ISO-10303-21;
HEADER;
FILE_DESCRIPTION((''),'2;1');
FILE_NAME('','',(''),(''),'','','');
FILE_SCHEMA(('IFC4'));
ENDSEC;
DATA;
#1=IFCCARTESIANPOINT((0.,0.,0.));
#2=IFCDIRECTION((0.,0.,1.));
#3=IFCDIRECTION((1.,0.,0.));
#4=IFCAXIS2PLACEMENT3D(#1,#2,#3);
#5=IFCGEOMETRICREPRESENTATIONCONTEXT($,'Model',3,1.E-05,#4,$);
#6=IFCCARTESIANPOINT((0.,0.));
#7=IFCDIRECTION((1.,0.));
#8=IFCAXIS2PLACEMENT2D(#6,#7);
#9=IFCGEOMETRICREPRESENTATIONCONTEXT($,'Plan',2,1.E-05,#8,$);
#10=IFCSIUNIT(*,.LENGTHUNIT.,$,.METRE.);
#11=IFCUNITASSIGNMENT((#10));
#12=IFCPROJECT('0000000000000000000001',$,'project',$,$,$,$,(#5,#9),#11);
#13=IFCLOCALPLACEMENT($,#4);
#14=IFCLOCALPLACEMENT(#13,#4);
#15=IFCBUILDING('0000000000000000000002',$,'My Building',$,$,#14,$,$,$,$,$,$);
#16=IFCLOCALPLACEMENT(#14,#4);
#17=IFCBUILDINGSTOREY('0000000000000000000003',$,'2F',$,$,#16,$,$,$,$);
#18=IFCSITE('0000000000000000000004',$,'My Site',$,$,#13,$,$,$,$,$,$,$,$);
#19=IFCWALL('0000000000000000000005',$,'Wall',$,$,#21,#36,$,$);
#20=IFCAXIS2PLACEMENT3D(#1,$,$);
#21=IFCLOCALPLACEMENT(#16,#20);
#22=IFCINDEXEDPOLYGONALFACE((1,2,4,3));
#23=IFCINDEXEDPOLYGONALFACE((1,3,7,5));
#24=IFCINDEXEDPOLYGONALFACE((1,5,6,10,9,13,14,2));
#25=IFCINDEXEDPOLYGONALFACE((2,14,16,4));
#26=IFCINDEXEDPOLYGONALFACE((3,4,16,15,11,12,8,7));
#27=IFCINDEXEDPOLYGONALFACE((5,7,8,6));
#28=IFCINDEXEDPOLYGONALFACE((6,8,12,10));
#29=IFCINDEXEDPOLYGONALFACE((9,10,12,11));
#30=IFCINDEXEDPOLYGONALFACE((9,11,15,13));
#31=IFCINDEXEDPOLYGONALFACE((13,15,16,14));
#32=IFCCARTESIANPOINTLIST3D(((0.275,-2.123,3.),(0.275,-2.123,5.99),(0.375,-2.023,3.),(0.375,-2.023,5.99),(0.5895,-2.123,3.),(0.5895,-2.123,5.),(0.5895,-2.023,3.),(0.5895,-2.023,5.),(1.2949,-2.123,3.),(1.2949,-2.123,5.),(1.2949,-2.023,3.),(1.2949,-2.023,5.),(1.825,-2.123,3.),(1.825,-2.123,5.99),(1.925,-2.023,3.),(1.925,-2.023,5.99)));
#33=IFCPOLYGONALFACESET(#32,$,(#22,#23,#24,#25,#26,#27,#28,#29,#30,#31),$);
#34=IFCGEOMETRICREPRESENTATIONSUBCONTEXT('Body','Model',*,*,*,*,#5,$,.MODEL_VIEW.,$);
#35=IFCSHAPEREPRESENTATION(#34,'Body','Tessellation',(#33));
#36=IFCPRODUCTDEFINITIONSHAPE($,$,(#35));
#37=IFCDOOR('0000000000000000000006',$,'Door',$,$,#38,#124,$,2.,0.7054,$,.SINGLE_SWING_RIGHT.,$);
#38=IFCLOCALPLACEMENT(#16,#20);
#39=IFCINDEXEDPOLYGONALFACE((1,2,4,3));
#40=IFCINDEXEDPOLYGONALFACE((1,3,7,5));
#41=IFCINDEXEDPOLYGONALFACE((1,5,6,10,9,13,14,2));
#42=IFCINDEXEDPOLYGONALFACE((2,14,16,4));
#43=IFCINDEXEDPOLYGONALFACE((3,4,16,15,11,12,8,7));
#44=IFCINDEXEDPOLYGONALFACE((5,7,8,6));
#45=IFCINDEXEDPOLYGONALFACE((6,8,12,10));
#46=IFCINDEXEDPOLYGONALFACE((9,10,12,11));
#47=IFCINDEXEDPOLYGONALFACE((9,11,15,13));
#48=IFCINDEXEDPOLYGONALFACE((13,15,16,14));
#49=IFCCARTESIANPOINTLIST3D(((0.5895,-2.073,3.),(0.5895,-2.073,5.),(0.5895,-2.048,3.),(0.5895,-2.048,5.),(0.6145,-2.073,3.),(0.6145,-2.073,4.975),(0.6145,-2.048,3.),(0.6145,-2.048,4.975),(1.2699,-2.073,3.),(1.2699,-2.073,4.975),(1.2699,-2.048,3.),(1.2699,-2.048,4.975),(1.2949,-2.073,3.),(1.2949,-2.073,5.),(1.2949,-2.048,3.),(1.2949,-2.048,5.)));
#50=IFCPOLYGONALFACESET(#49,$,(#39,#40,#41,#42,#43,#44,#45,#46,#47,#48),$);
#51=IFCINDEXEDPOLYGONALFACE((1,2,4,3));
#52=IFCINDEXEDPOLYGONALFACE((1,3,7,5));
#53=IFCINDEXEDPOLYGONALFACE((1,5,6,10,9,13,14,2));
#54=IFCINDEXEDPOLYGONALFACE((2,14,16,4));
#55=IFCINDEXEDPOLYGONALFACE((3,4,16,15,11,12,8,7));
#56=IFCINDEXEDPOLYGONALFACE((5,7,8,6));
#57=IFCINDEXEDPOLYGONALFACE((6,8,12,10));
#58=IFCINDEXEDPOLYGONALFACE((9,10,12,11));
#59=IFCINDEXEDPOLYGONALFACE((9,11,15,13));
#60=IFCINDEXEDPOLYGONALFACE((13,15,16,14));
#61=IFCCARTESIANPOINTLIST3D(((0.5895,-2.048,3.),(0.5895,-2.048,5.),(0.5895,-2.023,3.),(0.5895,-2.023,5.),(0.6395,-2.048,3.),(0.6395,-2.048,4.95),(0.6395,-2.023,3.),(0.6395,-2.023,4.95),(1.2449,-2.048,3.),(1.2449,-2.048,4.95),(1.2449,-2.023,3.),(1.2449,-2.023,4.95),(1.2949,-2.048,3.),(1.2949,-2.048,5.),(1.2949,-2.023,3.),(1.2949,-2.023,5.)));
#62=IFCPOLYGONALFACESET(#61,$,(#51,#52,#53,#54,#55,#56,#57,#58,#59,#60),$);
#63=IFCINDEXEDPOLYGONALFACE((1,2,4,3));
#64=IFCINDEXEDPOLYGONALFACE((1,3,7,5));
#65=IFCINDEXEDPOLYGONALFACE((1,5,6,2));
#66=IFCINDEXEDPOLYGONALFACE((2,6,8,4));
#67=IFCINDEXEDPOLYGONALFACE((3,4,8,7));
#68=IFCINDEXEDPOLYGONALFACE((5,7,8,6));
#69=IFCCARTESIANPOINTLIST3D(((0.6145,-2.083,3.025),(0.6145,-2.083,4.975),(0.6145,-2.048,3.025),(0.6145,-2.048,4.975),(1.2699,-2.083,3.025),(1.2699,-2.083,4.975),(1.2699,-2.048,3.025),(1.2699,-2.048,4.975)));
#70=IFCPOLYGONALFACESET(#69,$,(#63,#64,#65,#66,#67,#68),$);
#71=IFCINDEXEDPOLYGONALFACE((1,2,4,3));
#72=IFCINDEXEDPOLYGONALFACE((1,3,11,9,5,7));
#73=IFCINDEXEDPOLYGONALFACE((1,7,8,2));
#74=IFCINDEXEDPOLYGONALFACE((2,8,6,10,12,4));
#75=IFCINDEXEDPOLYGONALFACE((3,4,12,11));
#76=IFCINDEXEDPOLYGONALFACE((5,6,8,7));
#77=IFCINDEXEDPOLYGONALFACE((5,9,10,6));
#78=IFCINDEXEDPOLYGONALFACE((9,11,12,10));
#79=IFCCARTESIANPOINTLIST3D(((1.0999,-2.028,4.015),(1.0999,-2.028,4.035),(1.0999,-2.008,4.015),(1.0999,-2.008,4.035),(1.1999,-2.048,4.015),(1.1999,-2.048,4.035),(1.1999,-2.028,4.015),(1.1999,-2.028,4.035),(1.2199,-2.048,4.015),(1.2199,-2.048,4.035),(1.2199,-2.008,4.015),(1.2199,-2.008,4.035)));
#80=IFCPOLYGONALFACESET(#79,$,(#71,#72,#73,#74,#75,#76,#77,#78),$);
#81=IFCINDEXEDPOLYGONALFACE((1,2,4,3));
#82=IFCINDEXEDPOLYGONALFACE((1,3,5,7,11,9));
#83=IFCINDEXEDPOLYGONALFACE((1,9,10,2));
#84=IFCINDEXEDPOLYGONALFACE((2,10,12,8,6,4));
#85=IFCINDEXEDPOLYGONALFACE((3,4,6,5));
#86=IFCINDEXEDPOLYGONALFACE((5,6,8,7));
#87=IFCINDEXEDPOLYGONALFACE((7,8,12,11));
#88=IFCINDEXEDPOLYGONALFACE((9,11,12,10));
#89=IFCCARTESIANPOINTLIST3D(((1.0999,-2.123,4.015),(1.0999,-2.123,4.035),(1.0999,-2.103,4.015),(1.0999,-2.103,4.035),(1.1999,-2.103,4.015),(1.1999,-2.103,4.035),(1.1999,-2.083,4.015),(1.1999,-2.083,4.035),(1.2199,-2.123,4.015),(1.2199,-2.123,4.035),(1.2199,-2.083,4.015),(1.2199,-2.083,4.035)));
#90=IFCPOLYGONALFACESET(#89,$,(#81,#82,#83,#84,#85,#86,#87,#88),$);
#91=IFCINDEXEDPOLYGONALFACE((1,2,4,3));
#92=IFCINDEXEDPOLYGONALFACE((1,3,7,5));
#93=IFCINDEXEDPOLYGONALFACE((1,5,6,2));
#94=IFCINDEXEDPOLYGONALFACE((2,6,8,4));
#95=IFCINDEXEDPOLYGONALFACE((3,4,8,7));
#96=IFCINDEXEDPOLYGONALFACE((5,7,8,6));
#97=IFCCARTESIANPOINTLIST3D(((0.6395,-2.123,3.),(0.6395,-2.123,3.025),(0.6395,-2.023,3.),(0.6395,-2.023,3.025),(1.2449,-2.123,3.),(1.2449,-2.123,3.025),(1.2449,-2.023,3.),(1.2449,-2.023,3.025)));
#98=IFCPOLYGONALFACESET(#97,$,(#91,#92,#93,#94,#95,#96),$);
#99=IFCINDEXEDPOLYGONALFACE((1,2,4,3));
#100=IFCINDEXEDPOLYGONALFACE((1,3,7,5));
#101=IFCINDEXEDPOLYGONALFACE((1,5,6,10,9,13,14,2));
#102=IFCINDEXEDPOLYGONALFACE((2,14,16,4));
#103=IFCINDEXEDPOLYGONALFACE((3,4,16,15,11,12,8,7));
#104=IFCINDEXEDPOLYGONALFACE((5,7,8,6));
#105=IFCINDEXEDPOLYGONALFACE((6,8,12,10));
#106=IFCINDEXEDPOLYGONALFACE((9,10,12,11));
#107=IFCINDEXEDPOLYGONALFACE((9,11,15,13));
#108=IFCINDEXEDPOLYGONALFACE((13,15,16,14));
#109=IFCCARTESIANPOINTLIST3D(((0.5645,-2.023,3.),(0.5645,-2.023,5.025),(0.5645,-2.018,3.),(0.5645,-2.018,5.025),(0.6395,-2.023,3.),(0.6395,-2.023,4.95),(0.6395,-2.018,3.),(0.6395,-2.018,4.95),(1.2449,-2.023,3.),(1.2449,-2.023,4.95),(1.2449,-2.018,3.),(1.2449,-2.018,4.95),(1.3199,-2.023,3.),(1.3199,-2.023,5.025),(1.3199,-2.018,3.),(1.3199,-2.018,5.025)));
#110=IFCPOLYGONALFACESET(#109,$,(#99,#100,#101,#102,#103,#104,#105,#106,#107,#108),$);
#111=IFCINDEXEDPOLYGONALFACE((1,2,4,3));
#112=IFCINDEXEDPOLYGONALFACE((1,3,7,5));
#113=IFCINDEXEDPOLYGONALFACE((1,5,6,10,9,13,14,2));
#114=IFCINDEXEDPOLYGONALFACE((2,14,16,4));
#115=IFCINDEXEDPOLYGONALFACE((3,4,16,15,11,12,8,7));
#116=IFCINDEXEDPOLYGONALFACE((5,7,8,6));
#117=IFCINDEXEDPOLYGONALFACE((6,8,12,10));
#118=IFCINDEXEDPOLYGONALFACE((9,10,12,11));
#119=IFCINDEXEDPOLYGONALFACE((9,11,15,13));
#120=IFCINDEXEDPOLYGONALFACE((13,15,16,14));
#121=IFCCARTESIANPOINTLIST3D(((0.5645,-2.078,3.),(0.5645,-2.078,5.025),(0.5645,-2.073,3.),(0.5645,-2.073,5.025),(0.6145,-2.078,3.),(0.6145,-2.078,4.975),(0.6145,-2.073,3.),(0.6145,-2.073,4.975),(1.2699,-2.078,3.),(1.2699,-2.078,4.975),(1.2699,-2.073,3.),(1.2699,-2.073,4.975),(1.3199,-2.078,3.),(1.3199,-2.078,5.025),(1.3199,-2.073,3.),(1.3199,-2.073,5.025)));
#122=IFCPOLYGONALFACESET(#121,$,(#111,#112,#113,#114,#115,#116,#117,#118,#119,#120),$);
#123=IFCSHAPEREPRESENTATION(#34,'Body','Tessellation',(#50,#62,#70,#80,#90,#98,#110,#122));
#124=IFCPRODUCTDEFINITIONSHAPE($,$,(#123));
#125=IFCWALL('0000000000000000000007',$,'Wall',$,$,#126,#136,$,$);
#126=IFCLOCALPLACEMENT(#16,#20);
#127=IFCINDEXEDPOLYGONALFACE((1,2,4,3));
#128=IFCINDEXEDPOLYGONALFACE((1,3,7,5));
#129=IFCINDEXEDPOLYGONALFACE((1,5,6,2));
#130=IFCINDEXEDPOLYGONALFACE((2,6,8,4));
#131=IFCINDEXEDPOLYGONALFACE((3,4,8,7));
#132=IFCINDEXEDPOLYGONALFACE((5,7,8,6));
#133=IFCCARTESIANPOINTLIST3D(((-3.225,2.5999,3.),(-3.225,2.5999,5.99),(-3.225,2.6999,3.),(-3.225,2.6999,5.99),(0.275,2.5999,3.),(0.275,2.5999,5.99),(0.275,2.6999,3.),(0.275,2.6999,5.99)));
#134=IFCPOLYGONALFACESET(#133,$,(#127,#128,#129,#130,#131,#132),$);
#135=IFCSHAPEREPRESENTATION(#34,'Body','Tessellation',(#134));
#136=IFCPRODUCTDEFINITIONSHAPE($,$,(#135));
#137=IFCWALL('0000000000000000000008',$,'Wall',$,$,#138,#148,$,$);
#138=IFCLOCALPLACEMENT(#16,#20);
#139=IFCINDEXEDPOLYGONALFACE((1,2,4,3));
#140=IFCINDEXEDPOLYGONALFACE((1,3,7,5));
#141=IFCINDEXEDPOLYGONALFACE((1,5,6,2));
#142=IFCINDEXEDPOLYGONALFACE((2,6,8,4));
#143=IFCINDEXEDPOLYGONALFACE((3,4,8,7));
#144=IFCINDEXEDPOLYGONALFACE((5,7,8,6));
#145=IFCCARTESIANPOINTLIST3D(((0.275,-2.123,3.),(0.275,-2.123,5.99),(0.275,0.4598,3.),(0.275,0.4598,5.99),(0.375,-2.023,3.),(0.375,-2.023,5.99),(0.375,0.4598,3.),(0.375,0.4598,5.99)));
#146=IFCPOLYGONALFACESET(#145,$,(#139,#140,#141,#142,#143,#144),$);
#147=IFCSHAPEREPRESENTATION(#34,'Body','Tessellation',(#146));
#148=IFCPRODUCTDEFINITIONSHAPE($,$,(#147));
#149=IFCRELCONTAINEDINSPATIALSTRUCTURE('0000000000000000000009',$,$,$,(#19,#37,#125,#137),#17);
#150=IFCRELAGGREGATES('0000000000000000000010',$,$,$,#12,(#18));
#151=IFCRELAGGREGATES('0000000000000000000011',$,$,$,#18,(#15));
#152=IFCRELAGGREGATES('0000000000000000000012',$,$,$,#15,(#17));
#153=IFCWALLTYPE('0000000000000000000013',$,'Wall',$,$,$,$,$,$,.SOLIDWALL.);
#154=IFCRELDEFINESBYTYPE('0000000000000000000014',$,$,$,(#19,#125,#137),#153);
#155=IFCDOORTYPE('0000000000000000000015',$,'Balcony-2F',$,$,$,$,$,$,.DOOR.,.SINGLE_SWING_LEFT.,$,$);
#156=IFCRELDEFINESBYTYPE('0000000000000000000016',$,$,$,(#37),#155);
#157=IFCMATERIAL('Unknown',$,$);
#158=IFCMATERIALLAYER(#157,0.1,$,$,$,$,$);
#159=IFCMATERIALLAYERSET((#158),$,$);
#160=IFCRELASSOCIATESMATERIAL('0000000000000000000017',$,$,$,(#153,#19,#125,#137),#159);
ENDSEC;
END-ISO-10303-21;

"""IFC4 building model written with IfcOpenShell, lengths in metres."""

from ifc_helpers import new_model, entity, si_unit, frame, origin_with_axes, origin_2d_with_axis, place, context, subcontext, project, spatial, line, indexed_curve, outline, extrude, shape, source, transform, mapped, material, layer, layer_set, layer_usage, type_object, type_shapes, element, fill, save


model = new_model("IFC4")

# Units and contexts
model_context = context("Model", 3, precision=1e-05, world=origin_with_axes())
plan_context = context("Plan", 2, precision=1e-05, world=origin_2d_with_axis())
body_context_1 = subcontext(model_context, "Body", "Model", "MODEL_VIEW")
body_context_2 = subcontext(plan_context, "Body", "Plan", "PLAN_VIEW")
ifc_project = project(units=[si_unit("LENGTHUNIT", "METRE")], contexts=[model_context, plan_context])

# Site, building, storey
site_placement = place(None, origin_with_axes())
site = spatial("IfcSite", under=ifc_project, at=site_placement, Name="My Site")
building_placement = place(site_placement, origin_with_axes())
building = spatial("IfcBuilding", under=site, at=building_placement, Name="My Building")
storey_placement = place(building_placement, origin_with_axes())
storey = spatial("IfcBuildingStorey", under=building, at=storey_placement, Name="2F")

# Shared definitions
ifc_material = material(Name="Unknown")

# Shared definitions
ifc_layer_1 = layer(ifc_material, 0.1)
ifc_layer_set_1 = layer_set([ifc_layer_1])
wall_type = type_object("IfcWallType", Name="Wall", PredefinedType="SOLIDWALL", material=ifc_layer_set_1)

# Wall, opening, door
ifc_layer_usage_1 = layer_usage(ifc_layer_set_1, "AXIS2", "POSITIVE", 0.0)
wall_1_placement = place(storey_placement, frame((0.275, -2.123, 3.0), z_axis=(0.0, 0.0, 1.0), x_axis=(1.0, 0.000001, 0.0)))
wall_1 = element("IfcWall", 1, at=wall_1_placement, inside=storey, type_object=wall_type, material=ifc_layer_usage_1, Name="Wall", context=body_context_1, shape_type="SweptSolid", body=[
    extrude(outline(indexed_curve([(0.0, 0.0), (0.1, 0.1), (1.65, 0.1), (1.55, 0.0)], segments=[line(1, 2, 3, 4, 1)])), origin_with_axes(), (0.0, 0.0, 1.0), 2.99),
])
shared_shape_1 = source(origin_with_axes(), body_context_1, "Body", "SweptSolid", [
    extrude(outline(indexed_curve([(0.0, 0.0), (0.7054, 0.0), (0.7054, 2.0), (0.0, 2.0)], segments=[line(1, 2, 3, 4, 1)])), frame((0.0, -0.6, 0.0), z_axis=(0.0, -1.0, 0.0), x_axis=(1.0, 0.0, 0.0)), (0.0, 0.0, -1.0), 1.2),
])
opening_1_placement = place(wall_1_placement, frame((1.0199, 0.1, 0.0), z_axis=(0.0, 0.0, 1.0), x_axis=(-1.0, 0.0, 0.0)))
opening_1 = element("IfcOpeningElement", 2, at=opening_1_placement, cuts=wall_1, PredefinedType="OPENING", context=body_context_1, shape_type="MappedRepresentation", body=[
    mapped(shared_shape_1, transform((0.0, 0.0, 0.0), x_axis=(1.0, 0.0, 0.0), y_axis=(0.0, 1.0, 0.0), z_axis=(0.0, 0.0, 1.0), scale=1.0)),
])
door_type_1 = type_object("IfcDoorType", Name="Balcony-2F", OperationType="SINGLE_SWING_LEFT", PredefinedType="DOOR")
shared_shape_2 = source(origin_with_axes(), body_context_1, "Body", "SweptSolid", [
    extrude(outline(indexed_curve([(0.0, 0.0), (0.0, 2.0), (0.7054, 2.0), (0.7054, 0.0), (0.6804, 0.0), (0.6804, 1.975), (0.025, 1.975), (0.025, 0.0)], segments=[line(1, 2, 3, 4, 5, 6, 7, 8, 1)])), frame((0.0, 0.025, 0.0), z_axis=(0.0, -1.0, 0.0), x_axis=(1.0, 0.0, 0.0)), (0.0, 0.0, -1.0), 0.025),
    extrude(outline(indexed_curve([(0.0, 0.0), (0.0, 2.0), (0.7054, 2.0), (0.7054, 0.0), (0.6554, 0.0), (0.6554, 1.95), (0.05, 1.95), (0.05, 0.0)], segments=[line(1, 2, 3, 4, 5, 6, 7, 8, 1)])), frame((0.0, 0.0, 0.0), z_axis=(0.0, -1.0, 0.0), x_axis=(1.0, 0.0, 0.0)), (0.0, 0.0, -1.0), 0.025),
    extrude(outline(indexed_curve([(0.0, 0.0), (0.6554, 0.0), (0.6554, 0.035), (0.0, 0.035)], segments=[line(1, 2, 3, 4, 1)])), frame((0.025, 0.025, 0.025), z_axis=(0.0, 0.0, 1.0), x_axis=(1.0, 0.0, 0.0)), (0.0, 0.0, 1.0), 1.95),
    extrude(outline(indexed_curve([(0.0, 0.0), (0.0, -0.04), (0.12, -0.04), (0.12, -0.02), (0.02, -0.02), (0.02, 0.0)], segments=[line(1, 2, 3, 4, 5, 6, 1)])), frame((0.075, 0.025, 1.015), z_axis=(0.0, 0.0, 1.0), x_axis=(1.0, 0.0, 0.0)), (0.0, 0.0, 1.0), 0.02),
    extrude(outline(indexed_curve([(0.0, 0.0), (0.0, 0.04), (0.12, 0.04), (0.12, 0.02), (0.02, 0.02), (0.02, 0.0)], segments=[line(1, 2, 3, 4, 5, 6, 1)])), frame((0.075, 0.06, 1.015), z_axis=(0.0, 0.0, 1.0), x_axis=(1.0, 0.0, 0.0)), (0.0, 0.0, 1.0), 0.02),
    extrude(outline(indexed_curve([(0.0, 0.0), (0.6054, 0.0), (0.6054, 0.1), (0.0, 0.1)], segments=[line(1, 2, 3, 4, 1)])), frame((0.05, 0.0, 0.0), z_axis=(0.0, 0.0, 1.0), x_axis=(1.0, 0.0, 0.0)), (0.0, 0.0, 1.0), 0.025),
    extrude(outline(indexed_curve([(0.0, 0.0), (0.0, 2.025), (0.7554, 2.025), (0.7554, 0.0), (0.6804, 0.0), (0.6804, 1.95), (0.075, 1.95), (0.075, 0.0)], segments=[line(1, 2, 3, 4, 5, 6, 7, 8, 1)])), frame((-0.025, -0.005, 0.0), z_axis=(0.0, -1.0, 0.0), x_axis=(1.0, 0.0, 0.0)), (0.0, 0.0, -1.0), 0.005),
    extrude(outline(indexed_curve([(0.0, 0.0), (0.0, 2.025), (0.7554, 2.025), (0.7554, 0.0), (0.7054, 0.0), (0.7054, 1.975), (0.05, 1.975), (0.05, 0.0)], segments=[line(1, 2, 3, 4, 5, 6, 7, 8, 1)])), frame((-0.025, 0.05, 0.0), z_axis=(0.0, -1.0, 0.0), x_axis=(1.0, 0.0, 0.0)), (0.0, 0.0, -1.0), 0.005),
])
shared_shape_3 = source(origin_with_axes(), body_context_2, "Body", "Curve2D", [
    entity("IfcIndexedPolyCurve", entity("IfcCartesianPointList2D", [[0.0, 0.0], [0.0, 0.05], [0.025, 0.05], [0.025, 0.025], [0.05, 0.025], [0.05, 0.0]]), [entity("IfcLineIndex", [1, 2, 3, 4, 5, 6, 1])]),
    entity("IfcIndexedPolyCurve", entity("IfcCartesianPointList2D", [[0.7054, 0.0], [0.7054, 0.05], [0.6804, 0.05], [0.6804, 0.025], [0.6554, 0.025], [0.6554, 0.0]]), [entity("IfcLineIndex", [1, 2, 3, 4, 5, 6, 1])]),
    entity("IfcTrimmedCurve", entity("IfcEllipse", entity("IfcAxis2Placement2D", entity("IfcCartesianPoint", [0.6454, 0.05]), entity("IfcDirection", [1.0, 0.0])), 0.6204, 0.6554), [entity("IfcCartesianPoint", [0.6454, 0.7054])], [entity("IfcCartesianPoint", [0.025, 0.05])], True, "CARTESIAN"),
    entity("IfcIndexedPolyCurve", entity("IfcCartesianPointList2D", [[0.6804, 0.05], [0.6454, 0.05], [0.6454, 0.7054], [0.6804, 0.7054]]), [entity("IfcLineIndex", [1, 2, 3, 4, 1])]),
])
type_shapes(door_type_1, [shared_shape_2, shared_shape_3])
door_1_placement = place(opening_1_placement, frame((0.0, 0.0, 0.0), z_axis=(0.0, 0.0, 1.0), x_axis=(1.0, 0.0, 0.0)))
door_1 = element("IfcDoor", 3, at=door_1_placement, inside=storey, type_object=door_type_1, Name="Door", OperationType="SINGLE_SWING_RIGHT", OverallHeight=2.0, OverallWidth=0.7054, shapes=[
    shape(body_context_1, "Body", "MappedRepresentation", [mapped(shared_shape_2, transform((0.0, 0.0, 0.0), x_axis=(1.0, 0.0, 0.0), y_axis=(0.0, 1.0, 0.0), z_axis=(0.0, 0.0, 1.0), scale=1.0))]),
    shape(body_context_2, "Body", "MappedRepresentation", [mapped(shared_shape_3, transform((0.0, 0.0, 0.0), x_axis=(1.0, 0.0, 0.0), y_axis=(0.0, 1.0, 0.0), z_axis=(0.0, 0.0, 1.0), scale=1.0))]),
])
fill(opening_1, door_1)

# Walls
ifc_layer_usage_2 = layer_usage(ifc_layer_set_1, "AXIS2", "POSITIVE", 0.0)
wall_2_placement = place(storey_placement, frame((-3.225, 2.5999, 3.0), z_axis=(0.0, 0.0, 1.0), x_axis=(1.0, 0.0, 0.0)))
element("IfcWall", 4, at=wall_2_placement, inside=storey, type_object=wall_type, material=ifc_layer_usage_2, Name="Wall", context=body_context_1, shape_type="SweptSolid", body=[
    extrude(outline(indexed_curve([(0.0, 0.0), (0.0, 0.1), (3.5, 0.1), (3.5, 0.0)], segments=[line(1, 2, 3, 4, 1)])), origin_with_axes(), (0.0, 0.0, 1.0), 2.99),
])
ifc_layer_usage_3 = layer_usage(ifc_layer_set_1, "AXIS2", "POSITIVE", 0.0)
wall_3_placement = place(storey_placement, frame((0.275, 0.4598, 3.0), z_axis=(0.0, 0.0, 1.0), x_axis=(0.0, -1.0, 0.0)))
element("IfcWall", 5, at=wall_3_placement, inside=storey, type_object=wall_type, material=ifc_layer_usage_3, Name="Wall", context=body_context_1, shape_type="SweptSolid", body=[
    extrude(outline(indexed_curve([(0.0, 0.0), (0.0, 0.1), (2.4828, 0.1), (2.5828, 0.0)], segments=[line(1, 2, 3, 4, 1)])), origin_with_axes(), (0.0, 0.0, 1.0), 2.99),
])

save(model, "model.ifc")
